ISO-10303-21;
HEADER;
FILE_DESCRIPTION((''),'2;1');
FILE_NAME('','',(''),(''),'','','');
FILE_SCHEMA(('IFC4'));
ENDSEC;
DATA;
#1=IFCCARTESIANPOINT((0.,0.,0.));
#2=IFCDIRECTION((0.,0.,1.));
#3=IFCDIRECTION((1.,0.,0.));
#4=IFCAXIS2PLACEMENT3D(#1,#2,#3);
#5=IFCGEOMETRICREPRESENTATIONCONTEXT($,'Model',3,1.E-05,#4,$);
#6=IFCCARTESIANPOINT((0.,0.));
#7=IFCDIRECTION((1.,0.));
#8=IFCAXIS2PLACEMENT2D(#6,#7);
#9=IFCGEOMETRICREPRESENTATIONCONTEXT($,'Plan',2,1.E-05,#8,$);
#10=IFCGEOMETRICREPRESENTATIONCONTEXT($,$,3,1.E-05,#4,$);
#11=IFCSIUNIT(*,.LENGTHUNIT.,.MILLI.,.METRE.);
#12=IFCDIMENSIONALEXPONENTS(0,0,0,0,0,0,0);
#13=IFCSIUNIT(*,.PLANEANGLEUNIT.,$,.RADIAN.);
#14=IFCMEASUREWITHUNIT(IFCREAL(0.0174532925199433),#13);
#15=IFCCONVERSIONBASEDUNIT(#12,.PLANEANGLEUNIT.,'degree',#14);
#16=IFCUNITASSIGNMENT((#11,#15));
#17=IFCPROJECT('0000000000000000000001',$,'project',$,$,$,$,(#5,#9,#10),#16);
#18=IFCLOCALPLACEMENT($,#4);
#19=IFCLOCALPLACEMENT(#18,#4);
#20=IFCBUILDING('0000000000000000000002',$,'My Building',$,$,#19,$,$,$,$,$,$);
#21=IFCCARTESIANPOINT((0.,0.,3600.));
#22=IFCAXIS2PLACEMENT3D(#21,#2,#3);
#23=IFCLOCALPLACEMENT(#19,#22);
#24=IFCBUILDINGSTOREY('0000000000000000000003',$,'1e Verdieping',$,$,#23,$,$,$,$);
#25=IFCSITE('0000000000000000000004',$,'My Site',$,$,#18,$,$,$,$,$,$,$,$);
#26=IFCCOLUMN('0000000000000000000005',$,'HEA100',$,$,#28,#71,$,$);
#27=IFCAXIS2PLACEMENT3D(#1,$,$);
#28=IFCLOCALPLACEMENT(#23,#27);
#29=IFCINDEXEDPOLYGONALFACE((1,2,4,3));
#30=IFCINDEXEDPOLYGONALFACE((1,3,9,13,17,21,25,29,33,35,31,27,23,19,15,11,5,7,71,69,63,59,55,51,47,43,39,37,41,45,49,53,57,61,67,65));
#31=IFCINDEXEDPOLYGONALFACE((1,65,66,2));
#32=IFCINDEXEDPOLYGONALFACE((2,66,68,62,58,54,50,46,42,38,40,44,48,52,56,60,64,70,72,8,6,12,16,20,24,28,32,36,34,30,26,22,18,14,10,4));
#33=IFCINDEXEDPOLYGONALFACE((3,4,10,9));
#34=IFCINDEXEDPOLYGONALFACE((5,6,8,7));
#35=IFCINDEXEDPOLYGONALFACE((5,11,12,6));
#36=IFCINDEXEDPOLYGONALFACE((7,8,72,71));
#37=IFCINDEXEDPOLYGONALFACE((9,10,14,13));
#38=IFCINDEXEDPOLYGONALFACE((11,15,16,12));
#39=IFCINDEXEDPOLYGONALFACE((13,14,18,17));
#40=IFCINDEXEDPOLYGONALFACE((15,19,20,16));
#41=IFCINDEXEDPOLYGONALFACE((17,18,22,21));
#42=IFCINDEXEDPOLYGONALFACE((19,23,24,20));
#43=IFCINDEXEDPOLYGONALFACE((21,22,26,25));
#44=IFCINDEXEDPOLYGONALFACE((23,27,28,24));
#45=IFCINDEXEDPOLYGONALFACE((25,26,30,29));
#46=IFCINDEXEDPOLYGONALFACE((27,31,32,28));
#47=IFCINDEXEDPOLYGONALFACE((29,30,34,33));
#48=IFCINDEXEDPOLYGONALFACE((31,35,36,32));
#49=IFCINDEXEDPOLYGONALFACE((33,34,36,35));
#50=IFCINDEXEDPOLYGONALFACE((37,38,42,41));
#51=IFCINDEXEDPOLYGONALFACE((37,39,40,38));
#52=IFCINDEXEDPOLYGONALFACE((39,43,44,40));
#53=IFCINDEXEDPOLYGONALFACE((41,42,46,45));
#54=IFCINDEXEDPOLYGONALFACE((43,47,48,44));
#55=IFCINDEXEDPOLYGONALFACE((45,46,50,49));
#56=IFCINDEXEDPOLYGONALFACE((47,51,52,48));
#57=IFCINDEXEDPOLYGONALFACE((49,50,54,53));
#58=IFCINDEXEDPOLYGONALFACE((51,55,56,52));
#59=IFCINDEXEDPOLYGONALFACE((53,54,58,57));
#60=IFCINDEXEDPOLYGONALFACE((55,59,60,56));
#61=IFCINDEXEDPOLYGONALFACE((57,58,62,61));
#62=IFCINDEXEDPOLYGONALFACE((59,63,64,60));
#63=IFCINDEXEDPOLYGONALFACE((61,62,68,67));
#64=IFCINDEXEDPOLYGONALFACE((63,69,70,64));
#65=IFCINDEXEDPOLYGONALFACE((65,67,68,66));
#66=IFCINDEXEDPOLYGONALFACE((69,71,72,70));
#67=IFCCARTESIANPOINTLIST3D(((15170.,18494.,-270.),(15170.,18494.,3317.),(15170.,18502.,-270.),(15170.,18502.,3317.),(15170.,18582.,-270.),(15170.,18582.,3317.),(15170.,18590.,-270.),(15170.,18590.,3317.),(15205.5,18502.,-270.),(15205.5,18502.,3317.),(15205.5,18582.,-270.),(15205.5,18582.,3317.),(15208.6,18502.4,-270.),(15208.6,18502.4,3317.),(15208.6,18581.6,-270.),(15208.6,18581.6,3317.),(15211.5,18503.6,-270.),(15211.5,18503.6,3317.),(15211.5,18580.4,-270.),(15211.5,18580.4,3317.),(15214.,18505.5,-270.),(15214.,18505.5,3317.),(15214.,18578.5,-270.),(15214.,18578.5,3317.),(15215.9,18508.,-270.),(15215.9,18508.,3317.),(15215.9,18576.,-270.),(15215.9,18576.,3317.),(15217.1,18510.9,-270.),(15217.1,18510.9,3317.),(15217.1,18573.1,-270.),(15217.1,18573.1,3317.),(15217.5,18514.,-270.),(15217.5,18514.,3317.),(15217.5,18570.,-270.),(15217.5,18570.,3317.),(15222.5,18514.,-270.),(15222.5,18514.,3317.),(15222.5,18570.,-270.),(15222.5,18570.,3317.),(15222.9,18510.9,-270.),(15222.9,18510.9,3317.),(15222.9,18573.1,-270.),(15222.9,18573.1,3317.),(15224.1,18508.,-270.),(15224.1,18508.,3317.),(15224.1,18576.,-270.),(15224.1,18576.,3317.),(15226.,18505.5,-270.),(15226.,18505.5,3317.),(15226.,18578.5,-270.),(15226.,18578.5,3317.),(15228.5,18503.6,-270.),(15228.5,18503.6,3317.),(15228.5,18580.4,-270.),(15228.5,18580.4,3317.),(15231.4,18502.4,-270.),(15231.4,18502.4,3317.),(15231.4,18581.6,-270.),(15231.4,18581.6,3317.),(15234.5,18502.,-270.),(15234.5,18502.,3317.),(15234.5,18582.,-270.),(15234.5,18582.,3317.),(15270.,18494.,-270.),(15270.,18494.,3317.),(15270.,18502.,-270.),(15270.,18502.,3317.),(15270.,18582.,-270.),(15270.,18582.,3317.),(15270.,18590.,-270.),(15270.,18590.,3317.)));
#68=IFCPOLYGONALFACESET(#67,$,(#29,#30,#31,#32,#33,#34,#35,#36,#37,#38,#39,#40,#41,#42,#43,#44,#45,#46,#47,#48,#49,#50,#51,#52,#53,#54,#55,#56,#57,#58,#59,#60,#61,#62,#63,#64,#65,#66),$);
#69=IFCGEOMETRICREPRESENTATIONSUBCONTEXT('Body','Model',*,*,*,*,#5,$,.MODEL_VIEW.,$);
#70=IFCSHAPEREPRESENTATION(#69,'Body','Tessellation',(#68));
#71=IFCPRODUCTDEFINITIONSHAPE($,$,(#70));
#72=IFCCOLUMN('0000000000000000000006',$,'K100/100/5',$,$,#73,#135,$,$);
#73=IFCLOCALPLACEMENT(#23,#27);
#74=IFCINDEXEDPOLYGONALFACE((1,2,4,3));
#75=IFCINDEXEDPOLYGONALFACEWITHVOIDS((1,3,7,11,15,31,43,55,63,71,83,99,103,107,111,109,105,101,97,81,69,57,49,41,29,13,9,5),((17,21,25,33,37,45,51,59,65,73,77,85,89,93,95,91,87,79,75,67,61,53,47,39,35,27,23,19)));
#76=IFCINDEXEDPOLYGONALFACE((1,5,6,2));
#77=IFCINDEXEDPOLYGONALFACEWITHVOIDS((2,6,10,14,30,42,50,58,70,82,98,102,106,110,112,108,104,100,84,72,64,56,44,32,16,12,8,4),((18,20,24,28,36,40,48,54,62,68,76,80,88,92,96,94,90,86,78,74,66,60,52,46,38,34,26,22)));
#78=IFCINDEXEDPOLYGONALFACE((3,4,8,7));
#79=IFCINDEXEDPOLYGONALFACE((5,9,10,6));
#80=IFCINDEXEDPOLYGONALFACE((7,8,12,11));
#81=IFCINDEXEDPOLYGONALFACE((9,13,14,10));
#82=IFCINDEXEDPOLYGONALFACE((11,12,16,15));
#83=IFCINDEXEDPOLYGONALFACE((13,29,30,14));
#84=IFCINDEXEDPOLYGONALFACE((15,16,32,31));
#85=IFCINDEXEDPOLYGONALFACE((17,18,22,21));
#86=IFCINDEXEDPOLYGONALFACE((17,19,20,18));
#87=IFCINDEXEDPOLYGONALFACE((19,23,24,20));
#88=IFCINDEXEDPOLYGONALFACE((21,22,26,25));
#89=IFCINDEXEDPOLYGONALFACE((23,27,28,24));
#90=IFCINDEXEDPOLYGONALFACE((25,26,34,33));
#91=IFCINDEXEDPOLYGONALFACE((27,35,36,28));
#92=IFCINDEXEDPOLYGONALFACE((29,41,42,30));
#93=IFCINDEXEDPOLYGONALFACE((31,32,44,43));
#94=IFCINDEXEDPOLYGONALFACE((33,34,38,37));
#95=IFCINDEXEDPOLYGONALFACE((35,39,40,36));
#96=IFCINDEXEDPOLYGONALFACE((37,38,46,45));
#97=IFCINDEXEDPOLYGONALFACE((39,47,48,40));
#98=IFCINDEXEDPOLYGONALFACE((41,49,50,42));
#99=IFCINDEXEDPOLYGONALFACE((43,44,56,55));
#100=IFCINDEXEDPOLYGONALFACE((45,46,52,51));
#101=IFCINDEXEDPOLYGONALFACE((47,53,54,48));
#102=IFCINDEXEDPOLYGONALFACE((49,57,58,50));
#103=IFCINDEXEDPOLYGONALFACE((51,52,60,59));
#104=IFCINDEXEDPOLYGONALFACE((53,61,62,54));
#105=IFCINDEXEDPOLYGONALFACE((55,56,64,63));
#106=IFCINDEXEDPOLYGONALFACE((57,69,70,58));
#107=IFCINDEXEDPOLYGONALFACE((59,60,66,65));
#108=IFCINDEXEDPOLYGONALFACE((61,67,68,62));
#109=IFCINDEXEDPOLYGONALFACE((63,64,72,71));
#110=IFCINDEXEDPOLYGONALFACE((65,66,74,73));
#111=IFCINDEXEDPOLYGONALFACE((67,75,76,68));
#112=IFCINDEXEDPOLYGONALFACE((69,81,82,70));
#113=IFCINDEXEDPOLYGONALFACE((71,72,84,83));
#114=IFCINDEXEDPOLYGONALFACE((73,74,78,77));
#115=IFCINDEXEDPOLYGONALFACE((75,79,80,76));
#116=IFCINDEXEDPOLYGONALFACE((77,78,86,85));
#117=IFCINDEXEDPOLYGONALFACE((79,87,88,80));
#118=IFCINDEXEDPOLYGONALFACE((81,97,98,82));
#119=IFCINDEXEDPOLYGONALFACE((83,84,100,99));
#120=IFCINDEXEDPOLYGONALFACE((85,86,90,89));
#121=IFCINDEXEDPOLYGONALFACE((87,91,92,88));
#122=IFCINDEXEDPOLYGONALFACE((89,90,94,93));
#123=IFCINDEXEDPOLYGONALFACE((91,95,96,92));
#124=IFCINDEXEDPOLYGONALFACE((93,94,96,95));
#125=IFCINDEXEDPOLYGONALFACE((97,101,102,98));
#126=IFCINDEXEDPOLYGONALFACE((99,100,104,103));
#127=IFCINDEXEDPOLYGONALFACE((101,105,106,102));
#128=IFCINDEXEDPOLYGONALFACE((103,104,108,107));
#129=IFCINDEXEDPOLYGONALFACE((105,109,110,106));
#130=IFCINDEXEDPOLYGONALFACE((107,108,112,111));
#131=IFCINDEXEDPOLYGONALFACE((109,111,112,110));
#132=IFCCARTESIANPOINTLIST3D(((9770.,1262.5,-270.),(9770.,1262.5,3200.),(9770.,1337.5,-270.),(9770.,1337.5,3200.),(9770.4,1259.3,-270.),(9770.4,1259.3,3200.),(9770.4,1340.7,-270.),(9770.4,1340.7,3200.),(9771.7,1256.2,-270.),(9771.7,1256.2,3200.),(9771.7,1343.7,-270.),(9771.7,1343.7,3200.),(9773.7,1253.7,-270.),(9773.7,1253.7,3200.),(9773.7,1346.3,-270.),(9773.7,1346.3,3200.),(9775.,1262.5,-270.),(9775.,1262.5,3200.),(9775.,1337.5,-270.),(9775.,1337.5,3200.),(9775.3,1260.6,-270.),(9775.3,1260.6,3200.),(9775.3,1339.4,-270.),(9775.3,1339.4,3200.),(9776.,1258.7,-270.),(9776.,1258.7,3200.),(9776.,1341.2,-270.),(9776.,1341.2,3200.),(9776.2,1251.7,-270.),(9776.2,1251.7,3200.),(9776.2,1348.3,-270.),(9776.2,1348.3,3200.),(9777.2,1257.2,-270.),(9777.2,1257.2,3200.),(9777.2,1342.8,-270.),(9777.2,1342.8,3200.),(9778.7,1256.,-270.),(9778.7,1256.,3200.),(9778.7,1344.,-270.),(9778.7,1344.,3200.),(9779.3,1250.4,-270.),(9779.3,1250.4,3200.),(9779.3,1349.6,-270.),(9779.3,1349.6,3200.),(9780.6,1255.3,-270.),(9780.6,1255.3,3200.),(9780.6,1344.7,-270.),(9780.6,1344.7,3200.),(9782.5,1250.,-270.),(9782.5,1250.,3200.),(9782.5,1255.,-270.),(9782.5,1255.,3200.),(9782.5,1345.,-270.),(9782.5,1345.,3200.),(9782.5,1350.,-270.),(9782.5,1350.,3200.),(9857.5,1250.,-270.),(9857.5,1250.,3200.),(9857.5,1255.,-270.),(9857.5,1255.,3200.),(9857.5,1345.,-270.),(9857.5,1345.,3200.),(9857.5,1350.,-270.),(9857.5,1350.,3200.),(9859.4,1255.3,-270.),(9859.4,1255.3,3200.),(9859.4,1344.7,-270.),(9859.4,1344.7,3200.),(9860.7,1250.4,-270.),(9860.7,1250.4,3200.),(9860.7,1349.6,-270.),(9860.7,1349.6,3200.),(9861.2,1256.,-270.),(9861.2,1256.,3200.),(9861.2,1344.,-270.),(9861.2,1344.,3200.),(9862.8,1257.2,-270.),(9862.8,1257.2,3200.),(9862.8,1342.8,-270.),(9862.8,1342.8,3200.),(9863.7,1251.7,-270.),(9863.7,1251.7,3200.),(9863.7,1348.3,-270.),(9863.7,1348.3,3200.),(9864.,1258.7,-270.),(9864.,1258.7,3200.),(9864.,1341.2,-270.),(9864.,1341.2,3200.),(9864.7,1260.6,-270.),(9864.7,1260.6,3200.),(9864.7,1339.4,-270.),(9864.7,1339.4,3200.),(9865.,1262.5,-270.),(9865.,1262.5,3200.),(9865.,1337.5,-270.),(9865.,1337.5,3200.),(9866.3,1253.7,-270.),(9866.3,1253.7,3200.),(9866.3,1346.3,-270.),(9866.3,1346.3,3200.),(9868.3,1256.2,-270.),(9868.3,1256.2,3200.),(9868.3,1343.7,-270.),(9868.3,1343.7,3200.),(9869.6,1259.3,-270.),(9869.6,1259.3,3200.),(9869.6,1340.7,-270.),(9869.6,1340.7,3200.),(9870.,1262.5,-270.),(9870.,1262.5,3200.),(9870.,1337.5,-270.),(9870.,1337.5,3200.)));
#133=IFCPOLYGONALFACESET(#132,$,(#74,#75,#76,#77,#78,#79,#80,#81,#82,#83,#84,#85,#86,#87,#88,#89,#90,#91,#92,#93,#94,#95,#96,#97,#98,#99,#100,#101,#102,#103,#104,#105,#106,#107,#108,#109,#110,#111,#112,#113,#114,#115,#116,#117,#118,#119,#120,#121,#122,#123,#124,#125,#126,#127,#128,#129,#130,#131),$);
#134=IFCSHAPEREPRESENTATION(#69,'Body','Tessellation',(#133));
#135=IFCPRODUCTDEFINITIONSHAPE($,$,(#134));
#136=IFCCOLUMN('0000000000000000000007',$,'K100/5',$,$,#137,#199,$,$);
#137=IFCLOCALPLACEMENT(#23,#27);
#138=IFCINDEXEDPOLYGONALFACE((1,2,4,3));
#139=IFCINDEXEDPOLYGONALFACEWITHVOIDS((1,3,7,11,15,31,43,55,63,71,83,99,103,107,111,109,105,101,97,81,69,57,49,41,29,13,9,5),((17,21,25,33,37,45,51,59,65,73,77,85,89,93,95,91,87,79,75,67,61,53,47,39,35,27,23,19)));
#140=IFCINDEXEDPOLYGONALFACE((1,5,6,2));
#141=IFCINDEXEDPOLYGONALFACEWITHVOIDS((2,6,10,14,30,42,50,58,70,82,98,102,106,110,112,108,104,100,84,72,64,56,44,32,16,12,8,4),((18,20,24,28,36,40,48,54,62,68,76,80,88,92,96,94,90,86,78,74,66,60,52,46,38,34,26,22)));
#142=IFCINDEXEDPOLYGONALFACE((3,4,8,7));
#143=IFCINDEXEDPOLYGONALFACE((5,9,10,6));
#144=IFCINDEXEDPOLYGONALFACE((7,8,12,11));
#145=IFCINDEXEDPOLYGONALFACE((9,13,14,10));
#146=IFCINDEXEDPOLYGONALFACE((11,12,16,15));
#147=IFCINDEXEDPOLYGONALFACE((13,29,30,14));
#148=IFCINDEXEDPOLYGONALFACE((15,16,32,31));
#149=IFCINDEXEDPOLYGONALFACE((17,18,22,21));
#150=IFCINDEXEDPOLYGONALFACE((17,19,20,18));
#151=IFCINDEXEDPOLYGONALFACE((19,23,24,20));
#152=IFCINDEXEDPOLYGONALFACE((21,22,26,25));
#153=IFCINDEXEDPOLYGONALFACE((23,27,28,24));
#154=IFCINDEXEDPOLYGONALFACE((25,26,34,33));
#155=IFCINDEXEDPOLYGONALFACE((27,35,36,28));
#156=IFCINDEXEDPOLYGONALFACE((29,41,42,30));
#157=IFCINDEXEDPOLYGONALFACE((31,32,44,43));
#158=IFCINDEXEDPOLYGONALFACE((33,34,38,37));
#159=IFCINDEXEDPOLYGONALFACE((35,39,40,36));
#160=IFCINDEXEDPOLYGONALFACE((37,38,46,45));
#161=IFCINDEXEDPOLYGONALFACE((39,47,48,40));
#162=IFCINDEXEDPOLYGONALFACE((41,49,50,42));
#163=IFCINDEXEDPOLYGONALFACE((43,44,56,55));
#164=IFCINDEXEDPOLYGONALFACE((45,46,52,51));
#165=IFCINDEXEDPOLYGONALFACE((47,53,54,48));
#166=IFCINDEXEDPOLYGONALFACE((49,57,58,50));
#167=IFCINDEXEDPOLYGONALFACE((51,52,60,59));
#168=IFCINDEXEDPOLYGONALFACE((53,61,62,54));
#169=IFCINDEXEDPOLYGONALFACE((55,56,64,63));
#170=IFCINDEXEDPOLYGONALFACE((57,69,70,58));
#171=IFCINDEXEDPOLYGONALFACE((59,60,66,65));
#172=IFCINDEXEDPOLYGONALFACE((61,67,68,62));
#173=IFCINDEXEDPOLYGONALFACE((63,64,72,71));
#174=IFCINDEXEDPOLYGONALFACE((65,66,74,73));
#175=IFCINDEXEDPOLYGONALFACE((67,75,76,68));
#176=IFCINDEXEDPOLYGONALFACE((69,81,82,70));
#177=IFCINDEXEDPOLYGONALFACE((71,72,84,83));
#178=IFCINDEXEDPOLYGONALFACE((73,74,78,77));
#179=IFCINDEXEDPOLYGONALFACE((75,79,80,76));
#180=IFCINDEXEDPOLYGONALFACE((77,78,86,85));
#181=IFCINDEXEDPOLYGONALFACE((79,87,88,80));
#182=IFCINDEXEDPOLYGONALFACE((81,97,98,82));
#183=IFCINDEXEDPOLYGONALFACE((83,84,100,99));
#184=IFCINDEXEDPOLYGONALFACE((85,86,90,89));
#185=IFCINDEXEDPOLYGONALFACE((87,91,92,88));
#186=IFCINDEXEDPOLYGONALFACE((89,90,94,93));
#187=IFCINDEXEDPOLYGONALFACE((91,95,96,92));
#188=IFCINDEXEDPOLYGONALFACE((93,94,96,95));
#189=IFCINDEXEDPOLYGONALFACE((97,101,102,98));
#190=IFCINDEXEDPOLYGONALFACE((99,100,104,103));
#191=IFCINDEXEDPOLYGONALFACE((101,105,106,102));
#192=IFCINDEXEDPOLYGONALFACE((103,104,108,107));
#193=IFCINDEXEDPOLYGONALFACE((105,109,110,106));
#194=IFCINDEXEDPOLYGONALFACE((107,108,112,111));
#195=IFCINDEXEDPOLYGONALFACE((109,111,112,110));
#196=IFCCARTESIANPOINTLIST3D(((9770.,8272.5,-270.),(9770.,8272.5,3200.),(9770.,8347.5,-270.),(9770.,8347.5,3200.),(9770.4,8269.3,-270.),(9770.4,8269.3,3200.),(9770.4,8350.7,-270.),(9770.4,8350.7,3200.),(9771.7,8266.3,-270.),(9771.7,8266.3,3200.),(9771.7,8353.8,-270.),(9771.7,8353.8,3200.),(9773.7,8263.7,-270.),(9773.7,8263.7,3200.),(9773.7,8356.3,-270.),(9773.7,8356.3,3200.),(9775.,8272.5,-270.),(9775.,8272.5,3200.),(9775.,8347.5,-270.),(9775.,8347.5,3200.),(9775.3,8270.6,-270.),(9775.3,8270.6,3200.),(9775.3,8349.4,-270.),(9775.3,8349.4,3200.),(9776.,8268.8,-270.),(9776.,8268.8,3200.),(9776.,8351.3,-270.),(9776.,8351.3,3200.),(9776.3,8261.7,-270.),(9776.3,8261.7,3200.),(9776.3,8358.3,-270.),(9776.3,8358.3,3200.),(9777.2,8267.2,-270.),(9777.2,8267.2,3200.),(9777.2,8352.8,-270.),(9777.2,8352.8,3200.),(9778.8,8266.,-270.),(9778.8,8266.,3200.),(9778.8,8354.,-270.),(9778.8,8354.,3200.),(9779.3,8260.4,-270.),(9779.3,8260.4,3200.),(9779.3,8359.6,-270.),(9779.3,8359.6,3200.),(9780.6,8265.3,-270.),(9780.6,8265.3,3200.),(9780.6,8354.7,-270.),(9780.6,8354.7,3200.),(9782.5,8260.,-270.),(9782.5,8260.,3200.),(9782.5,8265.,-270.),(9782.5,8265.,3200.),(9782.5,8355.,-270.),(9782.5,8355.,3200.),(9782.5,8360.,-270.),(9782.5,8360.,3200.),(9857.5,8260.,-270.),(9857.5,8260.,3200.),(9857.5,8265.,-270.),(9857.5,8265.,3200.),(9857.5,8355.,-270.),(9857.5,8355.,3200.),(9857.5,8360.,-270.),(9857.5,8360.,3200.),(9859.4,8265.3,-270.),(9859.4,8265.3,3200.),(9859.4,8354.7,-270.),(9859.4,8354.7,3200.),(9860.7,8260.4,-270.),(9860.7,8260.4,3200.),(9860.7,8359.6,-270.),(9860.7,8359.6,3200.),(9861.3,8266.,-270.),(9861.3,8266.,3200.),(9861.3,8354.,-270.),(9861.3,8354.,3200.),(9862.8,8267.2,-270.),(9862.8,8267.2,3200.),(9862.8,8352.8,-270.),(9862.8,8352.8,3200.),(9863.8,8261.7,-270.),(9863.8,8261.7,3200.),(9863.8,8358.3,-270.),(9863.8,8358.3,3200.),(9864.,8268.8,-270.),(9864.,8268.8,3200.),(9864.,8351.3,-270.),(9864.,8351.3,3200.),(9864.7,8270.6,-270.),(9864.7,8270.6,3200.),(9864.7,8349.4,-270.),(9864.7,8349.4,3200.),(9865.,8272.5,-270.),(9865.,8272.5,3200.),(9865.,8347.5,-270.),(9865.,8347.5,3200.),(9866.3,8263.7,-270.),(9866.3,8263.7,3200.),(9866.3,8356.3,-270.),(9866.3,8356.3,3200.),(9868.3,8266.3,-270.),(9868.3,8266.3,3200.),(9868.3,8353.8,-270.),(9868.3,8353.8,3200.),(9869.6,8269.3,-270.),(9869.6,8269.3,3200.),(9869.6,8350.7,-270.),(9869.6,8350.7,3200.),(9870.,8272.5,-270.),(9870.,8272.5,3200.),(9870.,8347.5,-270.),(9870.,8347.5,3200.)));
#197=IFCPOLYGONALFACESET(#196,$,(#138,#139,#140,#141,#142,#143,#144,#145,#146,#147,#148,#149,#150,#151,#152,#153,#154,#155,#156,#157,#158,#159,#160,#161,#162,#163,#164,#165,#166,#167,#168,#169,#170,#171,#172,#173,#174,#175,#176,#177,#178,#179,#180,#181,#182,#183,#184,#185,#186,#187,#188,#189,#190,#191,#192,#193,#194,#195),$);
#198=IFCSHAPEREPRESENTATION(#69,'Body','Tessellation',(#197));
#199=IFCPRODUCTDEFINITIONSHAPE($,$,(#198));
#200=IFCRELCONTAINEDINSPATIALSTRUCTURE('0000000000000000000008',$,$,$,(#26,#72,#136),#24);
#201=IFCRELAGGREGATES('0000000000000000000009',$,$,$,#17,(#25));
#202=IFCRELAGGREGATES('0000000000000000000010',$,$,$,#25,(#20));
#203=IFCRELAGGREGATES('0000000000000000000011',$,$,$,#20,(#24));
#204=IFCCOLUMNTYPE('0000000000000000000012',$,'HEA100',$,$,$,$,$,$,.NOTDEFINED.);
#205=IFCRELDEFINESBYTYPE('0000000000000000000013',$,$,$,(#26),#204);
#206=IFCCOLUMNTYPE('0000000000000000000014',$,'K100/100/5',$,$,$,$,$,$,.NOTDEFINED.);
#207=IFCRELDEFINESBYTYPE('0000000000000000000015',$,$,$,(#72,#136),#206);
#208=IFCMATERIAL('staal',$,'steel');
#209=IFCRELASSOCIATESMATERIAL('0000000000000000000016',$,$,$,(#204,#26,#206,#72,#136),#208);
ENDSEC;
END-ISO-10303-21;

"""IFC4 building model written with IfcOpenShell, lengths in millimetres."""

from ifc_helpers import new_model, entity, si_unit, converted_unit, frame, origin_with_axes, origin_2d_with_axis, place, context, subcontext, project, spatial, hollow_rectangle, i_section, extrude, material, material_profile, profile_set, profile_usage, type_object, element, save


model = new_model("IFC4")

# Units and contexts
model_context = context("Model", 3, precision=1e-05, world=origin_with_axes())
plan_context = context("Plan", 2, precision=1e-05, world=origin_2d_with_axis())
context_of_model = context(None, 3, precision=1e-05, world=origin_with_axes())
body_context = subcontext(model_context, "Body", "Model", "MODEL_VIEW")
ifc_project = project(units=[si_unit("LENGTHUNIT", "METRE", prefix="MILLI"), converted_unit("PLANEANGLEUNIT", "degree", entity("IfcReal", 0.0174532925199433), si_unit("PLANEANGLEUNIT", "RADIAN"), dimensions=[0, 0, 0, 0, 0, 0, 0])], contexts=[model_context, plan_context, context_of_model])

# Site, building, storey
site_placement = place(None, origin_with_axes())
site = spatial("IfcSite", under=ifc_project, at=site_placement, Name="My Site")
building_placement = place(site_placement, origin_with_axes())
building = spatial("IfcBuilding", under=site, at=building_placement, Name="My Building")
storey_placement = place(building_placement, frame((0.0, 0.0, 3600.0), z_axis=(0.0, 0.0, 1.0), x_axis=(1.0, 0.0, 0.0)))
storey = spatial("IfcBuildingStorey", under=building, at=storey_placement, Name="1e Verdieping")

# Columns
ifc_material = material(Name="staal", Category="steel")
ifc_material_profile_1 = material_profile(ifc_material, i_section(OverallWidth=100.0, OverallDepth=96.0, WebThickness=5.0, FlangeThickness=8.0, FilletRadius=12.0))
ifc_profile_set_1 = profile_set([ifc_material_profile_1], Name="HEA100")
column_type_1 = type_object("IfcColumnType", Name="HEA100", PredefinedType="NOTDEFINED", material=ifc_profile_set_1)
ifc_profile_usage_1 = profile_usage(ifc_profile_set_1)
column_1_placement = place(storey_placement, frame((15220.0, 18542.0, -270.0), z_axis=(0.0, 0.0, 1.0), x_axis=(1.0, 0.0, 0.0)))
element("IfcColumn", 1, at=column_1_placement, inside=storey, type_object=column_type_1, material=ifc_profile_usage_1, Name="HEA100", context=body_context, shape_type="SweptSolid", body=[
    extrude(i_section(OverallWidth=100.0, OverallDepth=96.0, WebThickness=5.0, FlangeThickness=8.0, FilletRadius=12.0), origin_with_axes(), (0.0, 0.0, 1.0), 3587.0),
])
ifc_material_profile_2 = material_profile(ifc_material, hollow_rectangle(XDim=100.0, YDim=100.0, WallThickness=5.0, InnerFilletRadius=7.5, OuterFilletRadius=12.5))
ifc_profile_set_2 = profile_set([ifc_material_profile_2], Name="K100/100/5")
ifc_profile_usage_2 = profile_usage(ifc_profile_set_2, cardinal=5)
column_type_2 = type_object("IfcColumnType", Name="K100/100/5", PredefinedType="NOTDEFINED", material=ifc_profile_set_2)
column_2_placement = place(storey_placement, frame((9820.0, 1300.0, -270.0), z_axis=(0.0, 0.0, 1.0), x_axis=(1.0, 0.0, 0.0)))
element("IfcColumn", 2, at=column_2_placement, inside=storey, type_object=column_type_2, material=ifc_profile_usage_2, Name="K100/100/5", context=body_context, shape_type="SweptSolid", body=[
    extrude(hollow_rectangle(XDim=100.0, YDim=100.0, WallThickness=5.0, InnerFilletRadius=7.5, OuterFilletRadius=12.5), origin_with_axes(), (0.0, 0.0, 1.0), 3470.0),
])
ifc_profile_usage_3 = profile_usage(ifc_profile_set_2, cardinal=5)
column_3_placement = place(storey_placement, frame((9820.0, 8310.0, -270.0), z_axis=(0.0, 0.0, 1.0), x_axis=(1.0, 0.0, 0.0)))
element("IfcColumn", 3, at=column_3_placement, inside=storey, type_object=column_type_2, material=ifc_profile_usage_3, Name="K100/5", context=body_context, shape_type="SweptSolid", body=[
    extrude(hollow_rectangle(XDim=100.0, YDim=100.0, WallThickness=5.0, InnerFilletRadius=7.5, OuterFilletRadius=12.5), origin_with_axes(), (0.0, 0.0, 1.0), 3470.0),
])

save(model, "model.ifc")
